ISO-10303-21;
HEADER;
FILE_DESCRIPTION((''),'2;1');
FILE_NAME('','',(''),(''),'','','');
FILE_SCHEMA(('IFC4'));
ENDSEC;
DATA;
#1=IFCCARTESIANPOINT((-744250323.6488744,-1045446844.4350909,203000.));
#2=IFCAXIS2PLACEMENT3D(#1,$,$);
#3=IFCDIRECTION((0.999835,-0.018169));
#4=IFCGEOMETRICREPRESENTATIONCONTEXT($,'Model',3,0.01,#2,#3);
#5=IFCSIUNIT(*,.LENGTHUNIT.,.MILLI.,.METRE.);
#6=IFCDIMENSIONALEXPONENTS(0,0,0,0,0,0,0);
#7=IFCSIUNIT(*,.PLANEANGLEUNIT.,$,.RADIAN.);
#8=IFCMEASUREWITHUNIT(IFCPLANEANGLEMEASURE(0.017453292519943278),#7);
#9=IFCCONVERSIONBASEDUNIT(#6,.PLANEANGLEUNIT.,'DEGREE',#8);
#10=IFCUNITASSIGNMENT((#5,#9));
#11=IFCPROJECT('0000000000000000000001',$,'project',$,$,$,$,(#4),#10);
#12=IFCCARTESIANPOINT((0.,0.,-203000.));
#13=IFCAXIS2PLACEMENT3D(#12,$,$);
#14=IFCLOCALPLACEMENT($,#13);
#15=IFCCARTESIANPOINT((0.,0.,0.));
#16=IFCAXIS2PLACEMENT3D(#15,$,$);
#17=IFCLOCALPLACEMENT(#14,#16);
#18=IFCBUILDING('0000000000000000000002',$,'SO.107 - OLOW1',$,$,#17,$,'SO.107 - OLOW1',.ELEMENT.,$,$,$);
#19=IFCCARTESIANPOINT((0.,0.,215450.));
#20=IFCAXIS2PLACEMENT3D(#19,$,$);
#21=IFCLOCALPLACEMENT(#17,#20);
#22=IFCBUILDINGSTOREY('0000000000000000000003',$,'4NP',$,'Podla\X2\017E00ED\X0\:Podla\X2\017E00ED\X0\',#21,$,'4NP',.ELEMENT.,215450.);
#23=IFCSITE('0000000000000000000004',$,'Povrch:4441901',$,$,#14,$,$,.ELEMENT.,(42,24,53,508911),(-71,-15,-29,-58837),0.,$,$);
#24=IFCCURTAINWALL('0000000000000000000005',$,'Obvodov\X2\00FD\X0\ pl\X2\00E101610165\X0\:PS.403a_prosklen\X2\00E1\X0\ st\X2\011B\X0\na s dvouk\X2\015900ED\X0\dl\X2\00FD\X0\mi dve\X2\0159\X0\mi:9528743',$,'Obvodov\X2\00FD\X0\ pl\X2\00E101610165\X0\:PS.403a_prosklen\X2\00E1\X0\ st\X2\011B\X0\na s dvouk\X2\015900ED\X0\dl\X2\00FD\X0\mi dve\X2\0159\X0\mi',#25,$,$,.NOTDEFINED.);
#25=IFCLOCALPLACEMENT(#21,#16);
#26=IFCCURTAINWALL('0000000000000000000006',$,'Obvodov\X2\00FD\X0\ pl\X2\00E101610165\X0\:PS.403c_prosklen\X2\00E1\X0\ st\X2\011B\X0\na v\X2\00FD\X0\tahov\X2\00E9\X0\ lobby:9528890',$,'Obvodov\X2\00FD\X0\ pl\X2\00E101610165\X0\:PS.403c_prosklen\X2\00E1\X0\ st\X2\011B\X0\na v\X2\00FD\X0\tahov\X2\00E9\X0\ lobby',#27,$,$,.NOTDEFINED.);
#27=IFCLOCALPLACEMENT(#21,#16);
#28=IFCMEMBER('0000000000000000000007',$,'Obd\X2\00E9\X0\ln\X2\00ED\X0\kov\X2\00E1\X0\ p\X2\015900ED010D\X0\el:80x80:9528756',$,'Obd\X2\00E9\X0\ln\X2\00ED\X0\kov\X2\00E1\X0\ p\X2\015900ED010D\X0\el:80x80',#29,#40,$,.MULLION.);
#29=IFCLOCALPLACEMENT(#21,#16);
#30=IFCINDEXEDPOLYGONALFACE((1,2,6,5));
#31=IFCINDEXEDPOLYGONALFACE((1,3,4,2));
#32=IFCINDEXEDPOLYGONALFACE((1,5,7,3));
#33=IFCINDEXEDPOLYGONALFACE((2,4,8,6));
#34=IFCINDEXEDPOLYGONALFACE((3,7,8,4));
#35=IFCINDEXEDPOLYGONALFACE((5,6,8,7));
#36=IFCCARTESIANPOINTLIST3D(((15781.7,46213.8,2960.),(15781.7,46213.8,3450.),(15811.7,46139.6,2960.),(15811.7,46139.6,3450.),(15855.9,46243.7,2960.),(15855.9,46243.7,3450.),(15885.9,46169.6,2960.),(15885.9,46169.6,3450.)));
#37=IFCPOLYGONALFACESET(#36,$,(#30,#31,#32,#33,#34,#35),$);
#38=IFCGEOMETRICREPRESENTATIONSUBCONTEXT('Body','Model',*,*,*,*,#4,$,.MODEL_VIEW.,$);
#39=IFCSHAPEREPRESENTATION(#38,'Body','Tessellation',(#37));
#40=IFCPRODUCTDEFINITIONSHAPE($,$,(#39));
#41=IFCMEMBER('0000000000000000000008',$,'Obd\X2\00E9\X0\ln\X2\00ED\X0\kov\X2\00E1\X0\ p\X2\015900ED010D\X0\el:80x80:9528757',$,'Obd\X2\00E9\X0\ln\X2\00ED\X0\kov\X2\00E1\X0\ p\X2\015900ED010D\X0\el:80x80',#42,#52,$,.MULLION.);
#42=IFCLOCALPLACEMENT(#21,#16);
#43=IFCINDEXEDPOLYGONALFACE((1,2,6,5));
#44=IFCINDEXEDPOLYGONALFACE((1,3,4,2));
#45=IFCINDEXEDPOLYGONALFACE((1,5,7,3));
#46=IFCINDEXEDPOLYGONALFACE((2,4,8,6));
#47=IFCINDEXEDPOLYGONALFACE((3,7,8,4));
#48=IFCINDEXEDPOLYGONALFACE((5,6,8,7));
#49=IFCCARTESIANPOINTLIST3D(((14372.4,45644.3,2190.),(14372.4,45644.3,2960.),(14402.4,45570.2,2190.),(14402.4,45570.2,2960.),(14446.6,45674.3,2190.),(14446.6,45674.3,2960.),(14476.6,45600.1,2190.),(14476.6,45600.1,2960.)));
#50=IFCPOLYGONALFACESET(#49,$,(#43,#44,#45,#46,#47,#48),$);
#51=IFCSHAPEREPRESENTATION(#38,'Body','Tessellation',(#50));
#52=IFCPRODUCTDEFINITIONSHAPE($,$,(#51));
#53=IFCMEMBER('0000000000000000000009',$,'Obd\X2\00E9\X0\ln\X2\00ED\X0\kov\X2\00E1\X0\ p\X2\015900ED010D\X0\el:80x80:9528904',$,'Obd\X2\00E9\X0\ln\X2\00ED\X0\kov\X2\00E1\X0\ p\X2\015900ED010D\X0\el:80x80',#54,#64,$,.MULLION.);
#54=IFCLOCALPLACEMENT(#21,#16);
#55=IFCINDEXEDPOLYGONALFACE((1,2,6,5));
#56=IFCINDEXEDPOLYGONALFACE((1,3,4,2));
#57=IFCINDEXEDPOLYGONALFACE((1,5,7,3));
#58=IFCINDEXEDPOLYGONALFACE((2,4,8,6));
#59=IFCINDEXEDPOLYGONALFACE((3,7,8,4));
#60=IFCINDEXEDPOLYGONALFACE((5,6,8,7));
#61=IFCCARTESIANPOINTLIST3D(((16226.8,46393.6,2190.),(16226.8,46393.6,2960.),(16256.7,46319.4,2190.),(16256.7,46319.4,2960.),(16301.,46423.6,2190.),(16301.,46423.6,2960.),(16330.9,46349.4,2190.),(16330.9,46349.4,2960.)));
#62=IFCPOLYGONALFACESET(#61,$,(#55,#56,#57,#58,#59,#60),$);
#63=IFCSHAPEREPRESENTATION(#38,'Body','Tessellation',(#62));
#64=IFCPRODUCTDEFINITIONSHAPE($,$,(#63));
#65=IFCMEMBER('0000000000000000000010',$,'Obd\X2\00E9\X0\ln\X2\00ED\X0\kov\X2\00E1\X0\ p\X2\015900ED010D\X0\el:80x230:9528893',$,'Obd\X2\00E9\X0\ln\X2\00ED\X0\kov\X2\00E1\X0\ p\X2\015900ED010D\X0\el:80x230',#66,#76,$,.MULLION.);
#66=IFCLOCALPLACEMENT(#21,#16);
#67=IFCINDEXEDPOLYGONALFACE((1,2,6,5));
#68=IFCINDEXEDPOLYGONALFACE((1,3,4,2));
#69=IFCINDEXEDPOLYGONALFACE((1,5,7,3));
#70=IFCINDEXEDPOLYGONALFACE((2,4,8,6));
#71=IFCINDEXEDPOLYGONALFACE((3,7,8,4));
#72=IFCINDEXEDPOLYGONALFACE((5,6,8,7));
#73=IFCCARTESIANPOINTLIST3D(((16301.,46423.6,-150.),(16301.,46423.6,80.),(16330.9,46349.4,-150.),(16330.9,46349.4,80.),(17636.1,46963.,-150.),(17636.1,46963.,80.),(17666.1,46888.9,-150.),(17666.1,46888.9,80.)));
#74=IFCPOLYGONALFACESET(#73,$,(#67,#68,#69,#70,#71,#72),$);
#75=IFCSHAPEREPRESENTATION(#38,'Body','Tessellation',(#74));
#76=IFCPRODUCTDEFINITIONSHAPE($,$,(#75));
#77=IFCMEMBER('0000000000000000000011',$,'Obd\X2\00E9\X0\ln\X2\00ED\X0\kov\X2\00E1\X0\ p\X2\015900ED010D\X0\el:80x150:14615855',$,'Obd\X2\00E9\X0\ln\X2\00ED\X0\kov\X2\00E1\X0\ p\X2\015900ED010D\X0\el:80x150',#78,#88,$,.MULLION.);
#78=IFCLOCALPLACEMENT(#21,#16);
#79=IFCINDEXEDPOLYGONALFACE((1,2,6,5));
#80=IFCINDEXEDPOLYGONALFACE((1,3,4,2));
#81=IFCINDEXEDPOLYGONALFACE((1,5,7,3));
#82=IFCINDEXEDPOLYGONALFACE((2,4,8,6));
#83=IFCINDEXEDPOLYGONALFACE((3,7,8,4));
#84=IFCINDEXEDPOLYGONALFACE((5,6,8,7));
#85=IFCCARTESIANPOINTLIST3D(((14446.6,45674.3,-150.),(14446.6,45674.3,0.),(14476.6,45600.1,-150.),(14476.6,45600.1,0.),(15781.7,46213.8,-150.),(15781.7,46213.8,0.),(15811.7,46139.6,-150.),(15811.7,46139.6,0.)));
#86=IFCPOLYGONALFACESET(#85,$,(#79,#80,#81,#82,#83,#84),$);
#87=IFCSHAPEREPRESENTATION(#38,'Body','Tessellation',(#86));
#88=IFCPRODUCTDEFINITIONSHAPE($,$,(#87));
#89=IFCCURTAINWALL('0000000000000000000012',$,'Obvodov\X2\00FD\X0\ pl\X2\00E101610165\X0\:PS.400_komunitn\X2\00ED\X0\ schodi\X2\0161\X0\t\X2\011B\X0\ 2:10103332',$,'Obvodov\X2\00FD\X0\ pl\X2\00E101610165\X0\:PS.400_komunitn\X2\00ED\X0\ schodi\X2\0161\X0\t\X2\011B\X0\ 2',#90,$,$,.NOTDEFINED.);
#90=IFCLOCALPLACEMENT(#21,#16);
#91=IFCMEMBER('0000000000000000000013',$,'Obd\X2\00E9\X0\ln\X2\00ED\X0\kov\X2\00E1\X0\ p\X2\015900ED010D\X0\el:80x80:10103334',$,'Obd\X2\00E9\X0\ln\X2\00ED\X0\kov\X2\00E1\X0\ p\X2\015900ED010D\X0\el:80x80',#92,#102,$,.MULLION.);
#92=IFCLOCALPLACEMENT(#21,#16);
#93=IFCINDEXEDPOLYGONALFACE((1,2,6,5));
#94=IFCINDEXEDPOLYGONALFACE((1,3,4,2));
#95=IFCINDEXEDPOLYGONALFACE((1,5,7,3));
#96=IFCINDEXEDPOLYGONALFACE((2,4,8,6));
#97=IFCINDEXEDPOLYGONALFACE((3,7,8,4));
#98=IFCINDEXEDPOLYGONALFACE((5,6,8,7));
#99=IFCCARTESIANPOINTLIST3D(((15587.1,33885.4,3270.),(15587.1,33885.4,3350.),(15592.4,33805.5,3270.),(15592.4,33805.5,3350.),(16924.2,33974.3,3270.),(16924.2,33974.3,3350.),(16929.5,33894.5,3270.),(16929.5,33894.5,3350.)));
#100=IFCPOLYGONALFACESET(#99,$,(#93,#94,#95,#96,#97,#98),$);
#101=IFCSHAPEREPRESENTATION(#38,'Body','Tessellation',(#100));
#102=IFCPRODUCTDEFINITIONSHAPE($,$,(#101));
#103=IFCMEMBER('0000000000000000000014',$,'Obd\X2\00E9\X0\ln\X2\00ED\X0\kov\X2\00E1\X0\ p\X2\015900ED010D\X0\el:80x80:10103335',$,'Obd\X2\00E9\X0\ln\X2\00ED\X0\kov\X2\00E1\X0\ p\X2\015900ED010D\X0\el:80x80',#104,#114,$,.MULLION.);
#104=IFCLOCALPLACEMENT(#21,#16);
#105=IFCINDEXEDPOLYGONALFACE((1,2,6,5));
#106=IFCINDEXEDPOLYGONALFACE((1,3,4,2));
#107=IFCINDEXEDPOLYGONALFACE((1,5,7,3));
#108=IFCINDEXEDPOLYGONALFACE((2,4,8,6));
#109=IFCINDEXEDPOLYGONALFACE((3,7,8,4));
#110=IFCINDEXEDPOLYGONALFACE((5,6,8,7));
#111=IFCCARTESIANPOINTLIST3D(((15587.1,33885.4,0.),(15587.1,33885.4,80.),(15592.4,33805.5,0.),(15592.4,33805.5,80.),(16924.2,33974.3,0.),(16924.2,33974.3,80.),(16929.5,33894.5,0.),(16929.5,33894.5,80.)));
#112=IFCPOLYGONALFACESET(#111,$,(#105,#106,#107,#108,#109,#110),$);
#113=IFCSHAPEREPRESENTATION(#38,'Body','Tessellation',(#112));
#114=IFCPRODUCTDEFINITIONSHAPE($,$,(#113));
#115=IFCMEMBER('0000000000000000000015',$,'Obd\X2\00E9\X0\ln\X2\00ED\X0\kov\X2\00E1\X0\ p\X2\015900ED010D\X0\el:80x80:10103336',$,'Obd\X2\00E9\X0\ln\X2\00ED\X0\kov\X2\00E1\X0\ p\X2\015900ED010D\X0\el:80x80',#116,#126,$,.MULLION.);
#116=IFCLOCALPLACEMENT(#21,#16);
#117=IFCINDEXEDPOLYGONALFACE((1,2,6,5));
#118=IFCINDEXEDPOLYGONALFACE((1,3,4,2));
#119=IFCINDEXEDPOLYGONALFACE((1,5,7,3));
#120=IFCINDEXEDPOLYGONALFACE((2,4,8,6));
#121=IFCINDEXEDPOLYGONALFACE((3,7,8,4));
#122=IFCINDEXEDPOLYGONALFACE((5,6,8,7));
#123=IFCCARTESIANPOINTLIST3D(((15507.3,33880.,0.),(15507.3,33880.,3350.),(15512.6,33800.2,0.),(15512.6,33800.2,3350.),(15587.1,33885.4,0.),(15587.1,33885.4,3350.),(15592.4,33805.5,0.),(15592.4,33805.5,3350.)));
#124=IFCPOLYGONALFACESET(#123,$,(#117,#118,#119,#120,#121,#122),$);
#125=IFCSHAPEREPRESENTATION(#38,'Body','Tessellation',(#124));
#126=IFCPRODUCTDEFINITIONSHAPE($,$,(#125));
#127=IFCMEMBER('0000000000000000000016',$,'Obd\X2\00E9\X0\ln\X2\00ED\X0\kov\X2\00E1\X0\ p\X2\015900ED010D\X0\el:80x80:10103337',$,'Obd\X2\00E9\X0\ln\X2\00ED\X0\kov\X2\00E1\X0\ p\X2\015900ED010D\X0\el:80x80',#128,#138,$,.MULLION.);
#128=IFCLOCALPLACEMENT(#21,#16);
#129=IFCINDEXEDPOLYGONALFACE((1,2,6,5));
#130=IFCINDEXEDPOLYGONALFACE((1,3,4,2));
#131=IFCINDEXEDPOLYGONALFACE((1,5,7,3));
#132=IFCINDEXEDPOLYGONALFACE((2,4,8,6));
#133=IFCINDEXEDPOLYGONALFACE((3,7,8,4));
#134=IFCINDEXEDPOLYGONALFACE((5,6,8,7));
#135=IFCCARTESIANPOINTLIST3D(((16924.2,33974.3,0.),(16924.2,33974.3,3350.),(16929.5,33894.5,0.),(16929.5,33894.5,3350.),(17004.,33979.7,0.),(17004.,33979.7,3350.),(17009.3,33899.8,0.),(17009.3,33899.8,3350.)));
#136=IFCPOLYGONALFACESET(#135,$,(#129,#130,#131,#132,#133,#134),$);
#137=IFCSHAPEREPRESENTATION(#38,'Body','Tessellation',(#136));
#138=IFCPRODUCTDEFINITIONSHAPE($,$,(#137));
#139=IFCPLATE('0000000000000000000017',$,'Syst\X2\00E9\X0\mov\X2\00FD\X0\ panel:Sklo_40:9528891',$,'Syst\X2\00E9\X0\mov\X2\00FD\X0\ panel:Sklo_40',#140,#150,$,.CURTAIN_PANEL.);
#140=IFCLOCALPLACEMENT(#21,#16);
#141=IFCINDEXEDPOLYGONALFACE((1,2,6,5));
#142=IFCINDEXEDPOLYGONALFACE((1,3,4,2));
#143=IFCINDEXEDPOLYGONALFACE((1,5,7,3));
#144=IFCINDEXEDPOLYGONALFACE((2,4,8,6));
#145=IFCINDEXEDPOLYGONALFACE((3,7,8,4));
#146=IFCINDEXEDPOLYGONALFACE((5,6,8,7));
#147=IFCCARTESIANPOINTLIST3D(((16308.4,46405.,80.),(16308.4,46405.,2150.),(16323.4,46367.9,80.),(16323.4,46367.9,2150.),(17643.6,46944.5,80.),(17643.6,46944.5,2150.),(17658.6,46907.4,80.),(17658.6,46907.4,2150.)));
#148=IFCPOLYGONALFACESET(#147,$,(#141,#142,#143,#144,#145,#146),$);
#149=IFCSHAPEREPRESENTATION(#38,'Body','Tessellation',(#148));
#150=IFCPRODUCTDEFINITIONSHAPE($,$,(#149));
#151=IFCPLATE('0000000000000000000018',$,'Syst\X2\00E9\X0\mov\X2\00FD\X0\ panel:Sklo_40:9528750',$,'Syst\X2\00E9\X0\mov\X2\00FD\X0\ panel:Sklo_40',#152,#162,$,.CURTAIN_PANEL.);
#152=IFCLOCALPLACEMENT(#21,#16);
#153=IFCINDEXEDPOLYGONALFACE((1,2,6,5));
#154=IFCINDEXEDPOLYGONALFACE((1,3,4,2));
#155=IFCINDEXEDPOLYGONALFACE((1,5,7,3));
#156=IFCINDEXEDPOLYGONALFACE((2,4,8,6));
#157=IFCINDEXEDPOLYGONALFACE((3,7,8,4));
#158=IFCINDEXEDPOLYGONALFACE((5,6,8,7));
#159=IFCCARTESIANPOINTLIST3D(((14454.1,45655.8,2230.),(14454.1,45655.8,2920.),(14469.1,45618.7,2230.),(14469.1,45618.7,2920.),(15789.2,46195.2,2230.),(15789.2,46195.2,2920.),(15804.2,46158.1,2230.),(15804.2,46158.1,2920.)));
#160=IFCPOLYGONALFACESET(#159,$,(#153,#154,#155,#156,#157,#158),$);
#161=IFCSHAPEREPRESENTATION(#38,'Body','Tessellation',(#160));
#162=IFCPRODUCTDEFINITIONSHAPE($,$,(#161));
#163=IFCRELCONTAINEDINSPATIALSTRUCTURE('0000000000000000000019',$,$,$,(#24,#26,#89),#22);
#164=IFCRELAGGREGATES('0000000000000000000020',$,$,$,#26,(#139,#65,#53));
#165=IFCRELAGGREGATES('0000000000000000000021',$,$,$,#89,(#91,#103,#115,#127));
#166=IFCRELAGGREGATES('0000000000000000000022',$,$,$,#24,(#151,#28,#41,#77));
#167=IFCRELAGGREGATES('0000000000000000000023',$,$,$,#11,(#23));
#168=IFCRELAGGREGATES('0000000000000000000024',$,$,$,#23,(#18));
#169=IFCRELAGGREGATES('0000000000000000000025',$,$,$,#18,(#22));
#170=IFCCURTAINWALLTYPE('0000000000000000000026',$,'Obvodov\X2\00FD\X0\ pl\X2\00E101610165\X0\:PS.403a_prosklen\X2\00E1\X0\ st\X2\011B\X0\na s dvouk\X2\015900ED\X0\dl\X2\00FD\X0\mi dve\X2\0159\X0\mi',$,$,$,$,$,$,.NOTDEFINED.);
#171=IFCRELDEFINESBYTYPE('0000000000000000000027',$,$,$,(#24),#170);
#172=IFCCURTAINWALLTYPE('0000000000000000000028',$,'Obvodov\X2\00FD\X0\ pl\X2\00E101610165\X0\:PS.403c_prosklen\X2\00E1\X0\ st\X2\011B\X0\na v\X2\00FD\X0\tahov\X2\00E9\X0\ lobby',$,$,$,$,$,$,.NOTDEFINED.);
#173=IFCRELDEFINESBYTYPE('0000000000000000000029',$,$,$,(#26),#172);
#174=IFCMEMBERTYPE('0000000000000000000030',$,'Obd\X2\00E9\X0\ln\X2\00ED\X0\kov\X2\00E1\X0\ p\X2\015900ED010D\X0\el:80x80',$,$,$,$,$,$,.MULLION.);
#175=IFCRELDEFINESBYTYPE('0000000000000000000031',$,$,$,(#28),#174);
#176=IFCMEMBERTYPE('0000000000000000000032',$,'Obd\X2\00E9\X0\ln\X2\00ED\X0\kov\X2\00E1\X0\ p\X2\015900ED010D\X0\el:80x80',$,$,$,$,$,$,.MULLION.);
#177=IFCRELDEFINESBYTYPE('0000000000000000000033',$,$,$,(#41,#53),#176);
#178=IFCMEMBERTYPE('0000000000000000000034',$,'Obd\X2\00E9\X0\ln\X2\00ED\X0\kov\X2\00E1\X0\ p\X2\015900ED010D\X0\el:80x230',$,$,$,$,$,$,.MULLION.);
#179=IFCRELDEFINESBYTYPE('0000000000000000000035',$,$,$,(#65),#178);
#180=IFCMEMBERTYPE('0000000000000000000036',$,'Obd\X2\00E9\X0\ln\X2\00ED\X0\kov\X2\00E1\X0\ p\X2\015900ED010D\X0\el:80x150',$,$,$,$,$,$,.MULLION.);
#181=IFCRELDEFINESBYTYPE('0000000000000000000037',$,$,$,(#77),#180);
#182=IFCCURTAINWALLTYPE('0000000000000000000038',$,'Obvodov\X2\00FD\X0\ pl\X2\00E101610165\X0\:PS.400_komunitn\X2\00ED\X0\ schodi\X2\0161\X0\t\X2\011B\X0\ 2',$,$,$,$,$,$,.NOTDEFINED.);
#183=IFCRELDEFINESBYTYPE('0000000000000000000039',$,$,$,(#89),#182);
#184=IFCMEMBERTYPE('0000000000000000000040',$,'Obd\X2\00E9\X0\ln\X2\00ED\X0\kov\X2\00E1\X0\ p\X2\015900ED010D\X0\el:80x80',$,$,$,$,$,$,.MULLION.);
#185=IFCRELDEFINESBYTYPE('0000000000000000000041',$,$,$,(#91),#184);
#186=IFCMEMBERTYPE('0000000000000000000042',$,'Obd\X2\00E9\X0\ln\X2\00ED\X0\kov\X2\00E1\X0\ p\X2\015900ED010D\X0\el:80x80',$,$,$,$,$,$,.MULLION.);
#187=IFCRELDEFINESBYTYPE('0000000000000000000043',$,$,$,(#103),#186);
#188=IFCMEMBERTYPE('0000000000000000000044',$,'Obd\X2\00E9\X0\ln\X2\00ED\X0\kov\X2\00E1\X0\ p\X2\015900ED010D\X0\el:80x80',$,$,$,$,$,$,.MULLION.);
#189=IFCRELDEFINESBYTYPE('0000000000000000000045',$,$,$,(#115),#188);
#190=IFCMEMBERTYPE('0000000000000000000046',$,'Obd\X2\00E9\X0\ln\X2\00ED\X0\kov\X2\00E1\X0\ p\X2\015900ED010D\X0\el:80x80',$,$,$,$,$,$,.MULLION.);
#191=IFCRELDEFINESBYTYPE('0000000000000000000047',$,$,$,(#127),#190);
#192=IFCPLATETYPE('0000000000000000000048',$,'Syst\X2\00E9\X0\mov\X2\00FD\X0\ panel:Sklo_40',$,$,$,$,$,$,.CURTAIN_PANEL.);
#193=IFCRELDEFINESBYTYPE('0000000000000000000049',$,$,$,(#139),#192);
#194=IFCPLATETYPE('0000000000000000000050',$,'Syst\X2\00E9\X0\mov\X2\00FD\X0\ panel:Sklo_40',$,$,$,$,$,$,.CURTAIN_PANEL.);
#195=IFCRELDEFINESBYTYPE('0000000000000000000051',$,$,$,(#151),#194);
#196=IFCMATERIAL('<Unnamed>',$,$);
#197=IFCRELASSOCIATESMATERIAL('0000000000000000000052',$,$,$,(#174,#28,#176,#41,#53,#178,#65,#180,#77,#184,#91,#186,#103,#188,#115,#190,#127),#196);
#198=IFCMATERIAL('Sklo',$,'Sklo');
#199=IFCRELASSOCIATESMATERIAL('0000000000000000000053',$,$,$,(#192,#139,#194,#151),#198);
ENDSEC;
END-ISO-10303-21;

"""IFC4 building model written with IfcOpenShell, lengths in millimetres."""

from ifc_helpers import new_model, entity, si_unit, converted_unit, direction, frame, origin, place, context, subcontext, project, spatial, indexed_curve, outline, extrude, source, transform, mapped, material, type_object, type_shapes, element, aggregate, save


model = new_model("IFC4")

# Units and contexts
model_context = context("Model", 3, precision=0.01, world=frame((-744250323.6488744, -1045446844.4350909, 203000.0)), true_north=direction((0.999835, -0.018169)))
body_context = subcontext(model_context, "Body", "Model", "MODEL_VIEW")
ifc_project = project(units=[si_unit("LENGTHUNIT", "METRE", prefix="MILLI"), converted_unit("PLANEANGLEUNIT", "DEGREE", entity("IfcPlaneAngleMeasure", 0.017453292519943278), si_unit("PLANEANGLEUNIT", "RADIAN"), dimensions=[0, 0, 0, 0, 0, 0, 0])], contexts=[model_context])

# Site, building, storey
site_placement = place(None, frame((0.0, 0.0, -203000.0)))
site = spatial("IfcSite", under=ifc_project, at=site_placement, Name="Povrch:4441901", CompositionType="ELEMENT", RefLatitude=(42, 24, 53, 508911), RefLongitude=(-71, -15, -29, -58837), RefElevation=0.0)
building_placement = place(site_placement, origin())
building = spatial("IfcBuilding", under=site, at=building_placement, Name="SO.107 - OLOW1", LongName="SO.107 - OLOW1", CompositionType="ELEMENT")
storey_placement = place(building_placement, frame((0.0, 0.0, 215450.0)))
storey = spatial("IfcBuildingStorey", under=building, at=storey_placement, Name="4NP", ObjectType="Podlaží:Podlaží", LongName="4NP", CompositionType="ELEMENT", Elevation=215450.0)

# Curtain walls
curtain_wall_type_1 = type_object("IfcCurtainWallType", Name="Obvodový plášť:PS.403a_prosklená stěna s dvoukřídlými dveřmi", PredefinedType="NOTDEFINED")
curtain_wall_1_placement = place(storey_placement, frame((0.0, 0.0, -215450.0)))
curtain_wall_1 = element("IfcCurtainWall", 1, at=curtain_wall_1_placement, inside=storey, type_object=curtain_wall_type_1, Name="Obvodový plášť:PS.403a_prosklená stěna s dvoukřídlými dveřmi:9528743", ObjectType="Obvodový plášť:PS.403a_prosklená stěna s dvoukřídlými dveřmi", PredefinedType="NOTDEFINED")
ifc_material_1 = material(Name="<Unnamed>")
curtain_wall_type_2 = type_object("IfcCurtainWallType", Name="Obvodový plášť:PS.403c_prosklená stěna výtahové lobby", PredefinedType="NOTDEFINED")
curtain_wall_2_placement = place(storey_placement, frame((0.0, 0.0, -215450.0)))
curtain_wall_2 = element("IfcCurtainWall", 2, at=curtain_wall_2_placement, inside=storey, type_object=curtain_wall_type_2, Name="Obvodový plášť:PS.403c_prosklená stěna výtahové lobby:9528890", ObjectType="Obvodový plášť:PS.403c_prosklená stěna výtahové lobby", PredefinedType="NOTDEFINED")

# Members
member_type_1 = type_object("IfcMemberType", Name="Obdélníková příčel:80x80", PredefinedType="MULLION", material=ifc_material_1)
shared_shape_1 = source(origin(), body_context, "Body", "SweptSolid", [
    extrude(outline(indexed_curve([(-40.0, -40.0), (40.0, -40.0), (40.0, 40.0), (-40.0, 40.0), (-40.0, -40.0)], self_intersect=False)), frame((-40.0, 0.0, -490.0), z_axis=(0.0, 0.0, 1.0), x_axis=(-1.0, 0.0, 0.0)), (0.0, 0.0, 1.0), 490.0),
])
type_shapes(member_type_1, [shared_shape_1])
member_1_placement = place(curtain_wall_1_placement, frame((15870.9, 46206.7, 218410.0), z_axis=(0.0, 0.0, -1.0), x_axis=(0.927176, 0.374626, 0.0)))
member_1 = element("IfcMember", 3, at=member_1_placement, type_object=member_type_1, material=ifc_material_1, Name="Obdélníková příčel:80x80:9528756", ObjectType="Obdélníková příčel:80x80", PredefinedType="MULLION", context=body_context, shape_type="MappedRepresentation", body=[
    mapped(shared_shape_1, transform((0.0, 0.0, 0.0), scale=1.0)),
])
member_type_2 = type_object("IfcMemberType", Name="Obdélníková příčel:80x80", PredefinedType="MULLION", material=ifc_material_1)
shared_shape_2 = source(origin(), body_context, "Body", "SweptSolid", [
    extrude(outline(indexed_curve([(-40.0, -40.0), (40.0, -40.0), (40.0, 40.0), (-40.0, 40.0), (-40.0, -40.0)], self_intersect=False)), frame((-40.0, 0.0, -770.0), z_axis=(0.0, 0.0, 1.0), x_axis=(-1.0, 0.0, 0.0)), (0.0, 0.0, 1.0), 770.0),
])
type_shapes(member_type_2, [shared_shape_2])
member_2_placement = place(curtain_wall_1_placement, frame((14387.4, 45607.3, 218410.0), z_axis=(0.0, 0.0, 1.0), x_axis=(-0.927176, -0.374626, 0.0)))
member_2 = element("IfcMember", 4, at=member_2_placement, type_object=member_type_2, material=ifc_material_1, Name="Obdélníková příčel:80x80:9528757", ObjectType="Obdélníková příčel:80x80", PredefinedType="MULLION", context=body_context, shape_type="MappedRepresentation", body=[
    mapped(shared_shape_2, transform((0.0, 0.0, 0.0), scale=1.0)),
])
member_3_placement = place(curtain_wall_2_placement, frame((16241.8, 46356.5, 218410.0), z_axis=(0.0, 0.0, 1.0), x_axis=(-0.927176, -0.374626, 0.0)))
member_3 = element("IfcMember", 5, at=member_3_placement, type_object=member_type_2, material=ifc_material_1, Name="Obdélníková příčel:80x80:9528904", ObjectType="Obdélníková příčel:80x80", PredefinedType="MULLION", context=body_context, shape_type="MappedRepresentation", body=[
    mapped(shared_shape_2, transform((0.0, 0.0, 0.0), scale=1.0)),
])
member_type_3 = type_object("IfcMemberType", Name="Obdélníková příčel:80x230", PredefinedType="MULLION", material=ifc_material_1)
shared_shape_3 = source(origin(), body_context, "Body", "SweptSolid", [
    extrude(outline(indexed_curve([(-115.0, -40.0), (115.0, -40.0), (115.0, 40.0), (-115.0, 40.0), (-115.0, -40.0)], self_intersect=False)), frame((-115.0, 0.0, -1440.0), z_axis=(0.0, 0.0, 1.0), x_axis=(-1.0, 0.0, 0.0)), (0.0, 0.0, 1.0), 1440.0),
])
type_shapes(member_type_3, [shared_shape_3])
member_4_placement = place(curtain_wall_2_placement, frame((16315.9, 46386.5, 215300.0), z_axis=(-0.927176, -0.374626, 0.0), x_axis=(0.0, 0.0, -1.0)))
member_4 = element("IfcMember", 6, at=member_4_placement, type_object=member_type_3, material=ifc_material_1, Name="Obdélníková příčel:80x230:9528893", ObjectType="Obdélníková příčel:80x230", PredefinedType="MULLION", context=body_context, shape_type="MappedRepresentation", body=[
    mapped(shared_shape_3, transform((0.0, 0.0, 0.0), scale=1.0)),
])
member_type_4 = type_object("IfcMemberType", Name="Obdélníková příčel:80x150", PredefinedType="MULLION", material=ifc_material_1)
shared_shape_4 = source(origin(), body_context, "Body", "SweptSolid", [
    extrude(outline(indexed_curve([(-75.0, -40.0), (75.0, -40.0), (75.0, 40.0), (-75.0, 40.0), (-75.0, -40.0)], self_intersect=False)), frame((-75.0, 0.0, -1440.0), z_axis=(0.0, 0.0, 1.0), x_axis=(-1.0, 0.0, 0.0)), (0.0, 0.0, 1.0), 1440.0),
])
type_shapes(member_type_4, [shared_shape_4])
member_5_placement = place(curtain_wall_1_placement, frame((14461.6, 45637.2, 215300.0), z_axis=(-0.927176, -0.374626, 0.0), x_axis=(0.0, 0.0, -1.0)))
member_5 = element("IfcMember", 7, at=member_5_placement, type_object=member_type_4, material=ifc_material_1, Name="Obdélníková příčel:80x150:14615855", ObjectType="Obdélníková příčel:80x150", PredefinedType="MULLION", context=body_context, shape_type="MappedRepresentation", body=[
    mapped(shared_shape_4, transform((0.0, 0.0, 0.0), scale=1.0)),
])

# Curtain wall, members
curtain_wall_type_3 = type_object("IfcCurtainWallType", Name="Obvodový plášť:PS.400_komunitní schodiště 2", PredefinedType="NOTDEFINED")
curtain_wall_3_placement = place(storey_placement, frame((0.0, 0.0, -215450.0)))
curtain_wall_3 = element("IfcCurtainWall", 8, at=curtain_wall_3_placement, inside=storey, type_object=curtain_wall_type_3, Name="Obvodový plášť:PS.400_komunitní schodiště 2:10103332", ObjectType="Obvodový plášť:PS.400_komunitní schodiště 2", PredefinedType="NOTDEFINED")
member_type_5 = type_object("IfcMemberType", Name="Obdélníková příčel:80x80", PredefinedType="MULLION", material=ifc_material_1)
shared_shape_5 = source(origin(), body_context, "Body", "SweptSolid", [
    extrude(outline(indexed_curve([(-40.0, -40.0), (40.0, -40.0), (40.0, 40.0), (-40.0, 40.0), (-40.0, -40.0)], self_intersect=False)), frame((-40.0, 0.0, -1340.0), z_axis=(0.0, 0.0, 1.0), x_axis=(-1.0, 0.0, 0.0)), (0.0, 0.0, 1.0), 1340.0),
])
type_shapes(member_type_5, [shared_shape_5])
member_6_placement = place(curtain_wall_3_placement, frame((15589.8, 33845.4, 218800.0), z_axis=(-0.997792, -0.066409, 0.0), x_axis=(0.0, 0.0, 1.0)))
member_6 = element("IfcMember", 9, at=member_6_placement, type_object=member_type_5, material=ifc_material_1, Name="Obdélníková příčel:80x80:10103334", ObjectType="Obdélníková příčel:80x80", PredefinedType="MULLION", context=body_context, shape_type="MappedRepresentation", body=[
    mapped(shared_shape_5, transform((0.0, 0.0, 0.0), scale=1.0)),
])
member_type_6 = type_object("IfcMemberType", Name="Obdélníková příčel:80x80", PredefinedType="MULLION", material=ifc_material_1)
shared_shape_6 = source(origin(), body_context, "Body", "SweptSolid", [
    extrude(outline(indexed_curve([(-40.0, -40.0), (40.0, -40.0), (40.0, 40.0), (-40.0, 40.0), (-40.0, -40.0)], self_intersect=False)), frame((-40.0, 0.0, -1340.0), z_axis=(0.0, 0.0, 1.0), x_axis=(-1.0, 0.0, 0.0)), (0.0, 0.0, 1.0), 1340.0),
])
type_shapes(member_type_6, [shared_shape_6])
member_7_placement = place(curtain_wall_3_placement, frame((16926.8, 33934.4, 215450.0), z_axis=(0.997792, 0.066409, 0.0), x_axis=(0.0, 0.0, -1.0)))
member_7 = element("IfcMember", 10, at=member_7_placement, type_object=member_type_6, material=ifc_material_1, Name="Obdélníková příčel:80x80:10103335", ObjectType="Obdélníková příčel:80x80", PredefinedType="MULLION", context=body_context, shape_type="MappedRepresentation", body=[
    mapped(shared_shape_6, transform((0.0, 0.0, 0.0), scale=1.0)),
])
member_type_7 = type_object("IfcMemberType", Name="Obdélníková příčel:80x80", PredefinedType="MULLION", material=ifc_material_1)
shared_shape_7 = source(origin(), body_context, "Body", "SweptSolid", [
    extrude(outline(indexed_curve([(-40.0, -40.0), (40.0, -40.0), (40.0, 40.0), (-40.0, 40.0), (-40.0, -40.0)], self_intersect=False)), frame((-40.0, 0.0, -3350.0), z_axis=(0.0, 0.0, 1.0), x_axis=(-1.0, 0.0, 0.0)), (0.0, 0.0, 1.0), 3350.0),
])
type_shapes(member_type_7, [shared_shape_7])
member_8_placement = place(curtain_wall_3_placement, frame((15509.9, 33840.1, 215450.0), z_axis=(0.0, 0.0, -1.0), x_axis=(-0.997792, -0.066409, 0.0)))
member_8 = element("IfcMember", 11, at=member_8_placement, type_object=member_type_7, material=ifc_material_1, Name="Obdélníková příčel:80x80:10103336", ObjectType="Obdélníková příčel:80x80", PredefinedType="MULLION", context=body_context, shape_type="MappedRepresentation", body=[
    mapped(shared_shape_7, transform((0.0, 0.0, 0.0), scale=1.0)),
])
member_type_8 = type_object("IfcMemberType", Name="Obdélníková příčel:80x80", PredefinedType="MULLION", material=ifc_material_1)
shared_shape_8 = source(origin(), body_context, "Body", "SweptSolid", [
    extrude(outline(indexed_curve([(-40.0, -40.0), (40.0, -40.0), (40.0, 40.0), (-40.0, 40.0), (-40.0, -40.0)], self_intersect=False)), frame((-40.0, 0.0, -3350.0), z_axis=(0.0, 0.0, 1.0), x_axis=(-1.0, 0.0, 0.0)), (0.0, 0.0, 1.0), 3350.0),
])
type_shapes(member_type_8, [shared_shape_8])
member_9_placement = place(curtain_wall_3_placement, frame((17006.6, 33939.7, 218800.0), z_axis=(0.0, 0.0, 1.0), x_axis=(0.997792, 0.066409, 0.0)))
member_9 = element("IfcMember", 12, at=member_9_placement, type_object=member_type_8, material=ifc_material_1, Name="Obdélníková příčel:80x80:10103337", ObjectType="Obdélníková příčel:80x80", PredefinedType="MULLION", context=body_context, shape_type="MappedRepresentation", body=[
    mapped(shared_shape_8, transform((0.0, 0.0, 0.0), scale=1.0)),
])

# Plates
ifc_material_2 = material(Name="Sklo", Category="Sklo")
plate_type_1 = type_object("IfcPlateType", Name="Systémový panel:Sklo_40", PredefinedType="CURTAIN_PANEL", material=ifc_material_2)
shared_shape_9 = source(origin(), body_context, "Body", "SweptSolid", [
    extrude(outline(indexed_curve([(-20.0, -720.0), (20.0, -720.0), (20.0, 720.0), (-20.0, 720.0), (-20.0, -720.0)], self_intersect=False)), frame((0.0, 0.0, 0.0), z_axis=(0.0, 0.0, 1.0), x_axis=(0.0, 1.0, 0.0)), (0.0, 0.0, 1.0), 2070.0),
])
type_shapes(plate_type_1, [shared_shape_9])
plate_1_placement = place(curtain_wall_2_placement, frame((16983.5, 46656.2, 215530.0), z_axis=(0.0, 0.0, 1.0), x_axis=(0.927176, 0.374626, 0.0)))
plate_1 = element("IfcPlate", 13, at=plate_1_placement, type_object=plate_type_1, material=ifc_material_2, Name="Systémový panel:Sklo_40:9528891", ObjectType="Systémový panel:Sklo_40", PredefinedType="CURTAIN_PANEL", context=body_context, shape_type="MappedRepresentation", body=[
    mapped(shared_shape_9, transform((0.0, 0.0, 0.0), scale=1.0)),
])
plate_type_2 = type_object("IfcPlateType", Name="Systémový panel:Sklo_40", PredefinedType="CURTAIN_PANEL", material=ifc_material_2)
shared_shape_10 = source(origin(), body_context, "Body", "SweptSolid", [
    extrude(outline(indexed_curve([(-20.0, -720.0), (20.0, -720.0), (20.0, 720.0), (-20.0, 720.0), (-20.0, -720.0)], self_intersect=False)), frame((0.0, 0.0, 0.0), z_axis=(0.0, 0.0, 1.0), x_axis=(0.0, 1.0, 0.0)), (0.0, 0.0, 1.0), 690.0),
])
type_shapes(plate_type_2, [shared_shape_10])
plate_2_placement = place(curtain_wall_1_placement, frame((15129.2, 45907.0, 217680.0), z_axis=(0.0, 0.0, 1.0), x_axis=(0.927176, 0.374626, 0.0)))
plate_2 = element("IfcPlate", 14, at=plate_2_placement, type_object=plate_type_2, material=ifc_material_2, Name="Systémový panel:Sklo_40:9528750", ObjectType="Systémový panel:Sklo_40", PredefinedType="CURTAIN_PANEL", context=body_context, shape_type="MappedRepresentation", body=[
    mapped(shared_shape_10, transform((0.0, 0.0, 0.0), scale=1.0)),
])
aggregate(curtain_wall_2, [plate_1, member_4, member_3])

aggregate(curtain_wall_3, [member_6, member_7, member_8, member_9])

aggregate(curtain_wall_1, [plate_2, member_1, member_2, member_5])

save(model, "model.ifc")
